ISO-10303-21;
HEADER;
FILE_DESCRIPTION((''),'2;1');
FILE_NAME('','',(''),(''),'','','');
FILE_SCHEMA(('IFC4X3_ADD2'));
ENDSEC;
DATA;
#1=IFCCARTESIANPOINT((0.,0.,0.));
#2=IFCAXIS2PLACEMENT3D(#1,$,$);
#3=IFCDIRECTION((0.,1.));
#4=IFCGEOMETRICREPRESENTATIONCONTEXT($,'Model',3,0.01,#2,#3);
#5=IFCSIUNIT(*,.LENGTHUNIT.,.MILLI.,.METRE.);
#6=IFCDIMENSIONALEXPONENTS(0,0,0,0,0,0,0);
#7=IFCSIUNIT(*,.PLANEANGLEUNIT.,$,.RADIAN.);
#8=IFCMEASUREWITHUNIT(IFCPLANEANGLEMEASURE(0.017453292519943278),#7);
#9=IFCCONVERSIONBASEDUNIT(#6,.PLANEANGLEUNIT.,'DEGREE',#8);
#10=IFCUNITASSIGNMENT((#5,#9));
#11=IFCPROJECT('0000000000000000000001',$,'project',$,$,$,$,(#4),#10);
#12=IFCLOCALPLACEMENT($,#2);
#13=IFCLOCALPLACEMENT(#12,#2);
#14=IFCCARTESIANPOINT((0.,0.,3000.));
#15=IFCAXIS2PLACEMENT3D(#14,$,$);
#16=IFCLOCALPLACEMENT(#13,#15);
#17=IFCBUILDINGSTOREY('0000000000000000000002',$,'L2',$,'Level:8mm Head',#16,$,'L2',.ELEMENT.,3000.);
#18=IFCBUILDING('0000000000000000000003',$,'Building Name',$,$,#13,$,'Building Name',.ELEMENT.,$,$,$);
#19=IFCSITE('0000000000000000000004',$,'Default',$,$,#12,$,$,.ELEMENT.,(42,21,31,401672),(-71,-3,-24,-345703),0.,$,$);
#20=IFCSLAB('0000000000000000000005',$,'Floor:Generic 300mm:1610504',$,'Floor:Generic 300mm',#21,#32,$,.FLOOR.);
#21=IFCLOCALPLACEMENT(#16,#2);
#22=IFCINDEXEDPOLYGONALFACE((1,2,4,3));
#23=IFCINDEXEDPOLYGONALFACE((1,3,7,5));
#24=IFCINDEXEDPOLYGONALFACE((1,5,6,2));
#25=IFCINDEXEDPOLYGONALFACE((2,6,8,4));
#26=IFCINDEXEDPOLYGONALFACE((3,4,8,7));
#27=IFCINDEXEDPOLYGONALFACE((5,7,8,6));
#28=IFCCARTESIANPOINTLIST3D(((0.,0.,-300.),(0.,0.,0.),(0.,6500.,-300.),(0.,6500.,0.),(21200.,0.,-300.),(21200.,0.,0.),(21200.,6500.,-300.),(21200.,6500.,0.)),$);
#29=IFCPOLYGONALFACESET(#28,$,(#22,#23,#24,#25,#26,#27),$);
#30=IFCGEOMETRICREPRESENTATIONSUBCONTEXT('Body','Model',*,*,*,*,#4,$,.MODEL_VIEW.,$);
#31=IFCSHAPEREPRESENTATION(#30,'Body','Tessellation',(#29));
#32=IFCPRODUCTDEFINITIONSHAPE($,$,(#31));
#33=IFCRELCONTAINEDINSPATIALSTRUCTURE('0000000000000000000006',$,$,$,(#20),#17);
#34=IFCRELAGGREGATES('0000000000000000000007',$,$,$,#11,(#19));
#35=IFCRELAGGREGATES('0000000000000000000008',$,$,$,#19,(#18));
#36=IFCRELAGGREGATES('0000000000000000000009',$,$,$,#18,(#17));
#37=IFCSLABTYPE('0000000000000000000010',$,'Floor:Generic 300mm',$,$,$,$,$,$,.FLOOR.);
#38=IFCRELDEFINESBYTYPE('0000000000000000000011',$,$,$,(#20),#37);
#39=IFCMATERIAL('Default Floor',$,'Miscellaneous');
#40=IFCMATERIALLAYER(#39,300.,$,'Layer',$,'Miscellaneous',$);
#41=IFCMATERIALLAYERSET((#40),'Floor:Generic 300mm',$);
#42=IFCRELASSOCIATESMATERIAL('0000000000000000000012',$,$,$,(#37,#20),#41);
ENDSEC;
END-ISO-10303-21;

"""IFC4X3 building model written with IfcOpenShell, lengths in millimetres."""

from ifc_helpers import new_model, entity, si_unit, converted_unit, direction, frame, origin, origin_2d_with_axis, place, context, subcontext, project, spatial, rectangle, extrude, material, layer, layer_set, layer_usage, type_object, element, save


model = new_model("IFC4X3")

# Units and contexts
model_context = context("Model", 3, precision=0.01, world=origin(), true_north=direction((0.0, 1.0)))
body_context = subcontext(model_context, "Body", "Model", "MODEL_VIEW")
ifc_project = project(units=[si_unit("LENGTHUNIT", "METRE", prefix="MILLI"), converted_unit("PLANEANGLEUNIT", "DEGREE", entity("IfcPlaneAngleMeasure", 0.017453292519943278), si_unit("PLANEANGLEUNIT", "RADIAN"), dimensions=[0, 0, 0, 0, 0, 0, 0])], contexts=[model_context])

# Site, building, storey
site_placement = place(None, origin())
site = spatial("IfcSite", under=ifc_project, at=site_placement, Name="Default", CompositionType="ELEMENT", RefLatitude=(42, 21, 31, 401672), RefLongitude=(-71, -3, -24, -345703), RefElevation=0.0)
building_placement = place(site_placement, origin())
building = spatial("IfcBuilding", under=site, at=building_placement, Name="Building Name", LongName="Building Name", CompositionType="ELEMENT")
storey_placement = place(building_placement, frame((0.0, 0.0, 3000.0)))
storey = spatial("IfcBuildingStorey", under=building, at=storey_placement, Name="L2", ObjectType="Level:8mm Head", LongName="L2", CompositionType="ELEMENT", Elevation=3000.0)

# Slab
ifc_material = material(Name="Default Floor", Category="Miscellaneous")
ifc_layer = layer(ifc_material, 300.0, Name="Layer", Category="Miscellaneous")
ifc_layer_set = layer_set([ifc_layer], Name="Floor:Generic 300mm")
ifc_layer_usage = layer_usage(ifc_layer_set, "AXIS3", "POSITIVE", 0.0)
slab_type = type_object("IfcSlabType", Name="Floor:Generic 300mm", PredefinedType="FLOOR", material=ifc_layer_set)
slab_placement = place(storey_placement, origin())
element("IfcSlab", 1, at=slab_placement, inside=storey, type_object=slab_type, material=ifc_layer_usage, Name="Floor:Generic 300mm:1610504", ObjectType="Floor:Generic 300mm", PredefinedType="FLOOR", context=body_context, shape_type="SweptSolid", body=[
    extrude(rectangle(XDim=6500.0, YDim=21200.0, at=origin_2d_with_axis()), frame((10600.0, 3250.0, 0.0), z_axis=(0.0, 0.0, -1.0), x_axis=(0.0, 1.0, 0.0)), (0.0, 0.0, 1.0), 300.0),
])

save(model, "model.ifc")
